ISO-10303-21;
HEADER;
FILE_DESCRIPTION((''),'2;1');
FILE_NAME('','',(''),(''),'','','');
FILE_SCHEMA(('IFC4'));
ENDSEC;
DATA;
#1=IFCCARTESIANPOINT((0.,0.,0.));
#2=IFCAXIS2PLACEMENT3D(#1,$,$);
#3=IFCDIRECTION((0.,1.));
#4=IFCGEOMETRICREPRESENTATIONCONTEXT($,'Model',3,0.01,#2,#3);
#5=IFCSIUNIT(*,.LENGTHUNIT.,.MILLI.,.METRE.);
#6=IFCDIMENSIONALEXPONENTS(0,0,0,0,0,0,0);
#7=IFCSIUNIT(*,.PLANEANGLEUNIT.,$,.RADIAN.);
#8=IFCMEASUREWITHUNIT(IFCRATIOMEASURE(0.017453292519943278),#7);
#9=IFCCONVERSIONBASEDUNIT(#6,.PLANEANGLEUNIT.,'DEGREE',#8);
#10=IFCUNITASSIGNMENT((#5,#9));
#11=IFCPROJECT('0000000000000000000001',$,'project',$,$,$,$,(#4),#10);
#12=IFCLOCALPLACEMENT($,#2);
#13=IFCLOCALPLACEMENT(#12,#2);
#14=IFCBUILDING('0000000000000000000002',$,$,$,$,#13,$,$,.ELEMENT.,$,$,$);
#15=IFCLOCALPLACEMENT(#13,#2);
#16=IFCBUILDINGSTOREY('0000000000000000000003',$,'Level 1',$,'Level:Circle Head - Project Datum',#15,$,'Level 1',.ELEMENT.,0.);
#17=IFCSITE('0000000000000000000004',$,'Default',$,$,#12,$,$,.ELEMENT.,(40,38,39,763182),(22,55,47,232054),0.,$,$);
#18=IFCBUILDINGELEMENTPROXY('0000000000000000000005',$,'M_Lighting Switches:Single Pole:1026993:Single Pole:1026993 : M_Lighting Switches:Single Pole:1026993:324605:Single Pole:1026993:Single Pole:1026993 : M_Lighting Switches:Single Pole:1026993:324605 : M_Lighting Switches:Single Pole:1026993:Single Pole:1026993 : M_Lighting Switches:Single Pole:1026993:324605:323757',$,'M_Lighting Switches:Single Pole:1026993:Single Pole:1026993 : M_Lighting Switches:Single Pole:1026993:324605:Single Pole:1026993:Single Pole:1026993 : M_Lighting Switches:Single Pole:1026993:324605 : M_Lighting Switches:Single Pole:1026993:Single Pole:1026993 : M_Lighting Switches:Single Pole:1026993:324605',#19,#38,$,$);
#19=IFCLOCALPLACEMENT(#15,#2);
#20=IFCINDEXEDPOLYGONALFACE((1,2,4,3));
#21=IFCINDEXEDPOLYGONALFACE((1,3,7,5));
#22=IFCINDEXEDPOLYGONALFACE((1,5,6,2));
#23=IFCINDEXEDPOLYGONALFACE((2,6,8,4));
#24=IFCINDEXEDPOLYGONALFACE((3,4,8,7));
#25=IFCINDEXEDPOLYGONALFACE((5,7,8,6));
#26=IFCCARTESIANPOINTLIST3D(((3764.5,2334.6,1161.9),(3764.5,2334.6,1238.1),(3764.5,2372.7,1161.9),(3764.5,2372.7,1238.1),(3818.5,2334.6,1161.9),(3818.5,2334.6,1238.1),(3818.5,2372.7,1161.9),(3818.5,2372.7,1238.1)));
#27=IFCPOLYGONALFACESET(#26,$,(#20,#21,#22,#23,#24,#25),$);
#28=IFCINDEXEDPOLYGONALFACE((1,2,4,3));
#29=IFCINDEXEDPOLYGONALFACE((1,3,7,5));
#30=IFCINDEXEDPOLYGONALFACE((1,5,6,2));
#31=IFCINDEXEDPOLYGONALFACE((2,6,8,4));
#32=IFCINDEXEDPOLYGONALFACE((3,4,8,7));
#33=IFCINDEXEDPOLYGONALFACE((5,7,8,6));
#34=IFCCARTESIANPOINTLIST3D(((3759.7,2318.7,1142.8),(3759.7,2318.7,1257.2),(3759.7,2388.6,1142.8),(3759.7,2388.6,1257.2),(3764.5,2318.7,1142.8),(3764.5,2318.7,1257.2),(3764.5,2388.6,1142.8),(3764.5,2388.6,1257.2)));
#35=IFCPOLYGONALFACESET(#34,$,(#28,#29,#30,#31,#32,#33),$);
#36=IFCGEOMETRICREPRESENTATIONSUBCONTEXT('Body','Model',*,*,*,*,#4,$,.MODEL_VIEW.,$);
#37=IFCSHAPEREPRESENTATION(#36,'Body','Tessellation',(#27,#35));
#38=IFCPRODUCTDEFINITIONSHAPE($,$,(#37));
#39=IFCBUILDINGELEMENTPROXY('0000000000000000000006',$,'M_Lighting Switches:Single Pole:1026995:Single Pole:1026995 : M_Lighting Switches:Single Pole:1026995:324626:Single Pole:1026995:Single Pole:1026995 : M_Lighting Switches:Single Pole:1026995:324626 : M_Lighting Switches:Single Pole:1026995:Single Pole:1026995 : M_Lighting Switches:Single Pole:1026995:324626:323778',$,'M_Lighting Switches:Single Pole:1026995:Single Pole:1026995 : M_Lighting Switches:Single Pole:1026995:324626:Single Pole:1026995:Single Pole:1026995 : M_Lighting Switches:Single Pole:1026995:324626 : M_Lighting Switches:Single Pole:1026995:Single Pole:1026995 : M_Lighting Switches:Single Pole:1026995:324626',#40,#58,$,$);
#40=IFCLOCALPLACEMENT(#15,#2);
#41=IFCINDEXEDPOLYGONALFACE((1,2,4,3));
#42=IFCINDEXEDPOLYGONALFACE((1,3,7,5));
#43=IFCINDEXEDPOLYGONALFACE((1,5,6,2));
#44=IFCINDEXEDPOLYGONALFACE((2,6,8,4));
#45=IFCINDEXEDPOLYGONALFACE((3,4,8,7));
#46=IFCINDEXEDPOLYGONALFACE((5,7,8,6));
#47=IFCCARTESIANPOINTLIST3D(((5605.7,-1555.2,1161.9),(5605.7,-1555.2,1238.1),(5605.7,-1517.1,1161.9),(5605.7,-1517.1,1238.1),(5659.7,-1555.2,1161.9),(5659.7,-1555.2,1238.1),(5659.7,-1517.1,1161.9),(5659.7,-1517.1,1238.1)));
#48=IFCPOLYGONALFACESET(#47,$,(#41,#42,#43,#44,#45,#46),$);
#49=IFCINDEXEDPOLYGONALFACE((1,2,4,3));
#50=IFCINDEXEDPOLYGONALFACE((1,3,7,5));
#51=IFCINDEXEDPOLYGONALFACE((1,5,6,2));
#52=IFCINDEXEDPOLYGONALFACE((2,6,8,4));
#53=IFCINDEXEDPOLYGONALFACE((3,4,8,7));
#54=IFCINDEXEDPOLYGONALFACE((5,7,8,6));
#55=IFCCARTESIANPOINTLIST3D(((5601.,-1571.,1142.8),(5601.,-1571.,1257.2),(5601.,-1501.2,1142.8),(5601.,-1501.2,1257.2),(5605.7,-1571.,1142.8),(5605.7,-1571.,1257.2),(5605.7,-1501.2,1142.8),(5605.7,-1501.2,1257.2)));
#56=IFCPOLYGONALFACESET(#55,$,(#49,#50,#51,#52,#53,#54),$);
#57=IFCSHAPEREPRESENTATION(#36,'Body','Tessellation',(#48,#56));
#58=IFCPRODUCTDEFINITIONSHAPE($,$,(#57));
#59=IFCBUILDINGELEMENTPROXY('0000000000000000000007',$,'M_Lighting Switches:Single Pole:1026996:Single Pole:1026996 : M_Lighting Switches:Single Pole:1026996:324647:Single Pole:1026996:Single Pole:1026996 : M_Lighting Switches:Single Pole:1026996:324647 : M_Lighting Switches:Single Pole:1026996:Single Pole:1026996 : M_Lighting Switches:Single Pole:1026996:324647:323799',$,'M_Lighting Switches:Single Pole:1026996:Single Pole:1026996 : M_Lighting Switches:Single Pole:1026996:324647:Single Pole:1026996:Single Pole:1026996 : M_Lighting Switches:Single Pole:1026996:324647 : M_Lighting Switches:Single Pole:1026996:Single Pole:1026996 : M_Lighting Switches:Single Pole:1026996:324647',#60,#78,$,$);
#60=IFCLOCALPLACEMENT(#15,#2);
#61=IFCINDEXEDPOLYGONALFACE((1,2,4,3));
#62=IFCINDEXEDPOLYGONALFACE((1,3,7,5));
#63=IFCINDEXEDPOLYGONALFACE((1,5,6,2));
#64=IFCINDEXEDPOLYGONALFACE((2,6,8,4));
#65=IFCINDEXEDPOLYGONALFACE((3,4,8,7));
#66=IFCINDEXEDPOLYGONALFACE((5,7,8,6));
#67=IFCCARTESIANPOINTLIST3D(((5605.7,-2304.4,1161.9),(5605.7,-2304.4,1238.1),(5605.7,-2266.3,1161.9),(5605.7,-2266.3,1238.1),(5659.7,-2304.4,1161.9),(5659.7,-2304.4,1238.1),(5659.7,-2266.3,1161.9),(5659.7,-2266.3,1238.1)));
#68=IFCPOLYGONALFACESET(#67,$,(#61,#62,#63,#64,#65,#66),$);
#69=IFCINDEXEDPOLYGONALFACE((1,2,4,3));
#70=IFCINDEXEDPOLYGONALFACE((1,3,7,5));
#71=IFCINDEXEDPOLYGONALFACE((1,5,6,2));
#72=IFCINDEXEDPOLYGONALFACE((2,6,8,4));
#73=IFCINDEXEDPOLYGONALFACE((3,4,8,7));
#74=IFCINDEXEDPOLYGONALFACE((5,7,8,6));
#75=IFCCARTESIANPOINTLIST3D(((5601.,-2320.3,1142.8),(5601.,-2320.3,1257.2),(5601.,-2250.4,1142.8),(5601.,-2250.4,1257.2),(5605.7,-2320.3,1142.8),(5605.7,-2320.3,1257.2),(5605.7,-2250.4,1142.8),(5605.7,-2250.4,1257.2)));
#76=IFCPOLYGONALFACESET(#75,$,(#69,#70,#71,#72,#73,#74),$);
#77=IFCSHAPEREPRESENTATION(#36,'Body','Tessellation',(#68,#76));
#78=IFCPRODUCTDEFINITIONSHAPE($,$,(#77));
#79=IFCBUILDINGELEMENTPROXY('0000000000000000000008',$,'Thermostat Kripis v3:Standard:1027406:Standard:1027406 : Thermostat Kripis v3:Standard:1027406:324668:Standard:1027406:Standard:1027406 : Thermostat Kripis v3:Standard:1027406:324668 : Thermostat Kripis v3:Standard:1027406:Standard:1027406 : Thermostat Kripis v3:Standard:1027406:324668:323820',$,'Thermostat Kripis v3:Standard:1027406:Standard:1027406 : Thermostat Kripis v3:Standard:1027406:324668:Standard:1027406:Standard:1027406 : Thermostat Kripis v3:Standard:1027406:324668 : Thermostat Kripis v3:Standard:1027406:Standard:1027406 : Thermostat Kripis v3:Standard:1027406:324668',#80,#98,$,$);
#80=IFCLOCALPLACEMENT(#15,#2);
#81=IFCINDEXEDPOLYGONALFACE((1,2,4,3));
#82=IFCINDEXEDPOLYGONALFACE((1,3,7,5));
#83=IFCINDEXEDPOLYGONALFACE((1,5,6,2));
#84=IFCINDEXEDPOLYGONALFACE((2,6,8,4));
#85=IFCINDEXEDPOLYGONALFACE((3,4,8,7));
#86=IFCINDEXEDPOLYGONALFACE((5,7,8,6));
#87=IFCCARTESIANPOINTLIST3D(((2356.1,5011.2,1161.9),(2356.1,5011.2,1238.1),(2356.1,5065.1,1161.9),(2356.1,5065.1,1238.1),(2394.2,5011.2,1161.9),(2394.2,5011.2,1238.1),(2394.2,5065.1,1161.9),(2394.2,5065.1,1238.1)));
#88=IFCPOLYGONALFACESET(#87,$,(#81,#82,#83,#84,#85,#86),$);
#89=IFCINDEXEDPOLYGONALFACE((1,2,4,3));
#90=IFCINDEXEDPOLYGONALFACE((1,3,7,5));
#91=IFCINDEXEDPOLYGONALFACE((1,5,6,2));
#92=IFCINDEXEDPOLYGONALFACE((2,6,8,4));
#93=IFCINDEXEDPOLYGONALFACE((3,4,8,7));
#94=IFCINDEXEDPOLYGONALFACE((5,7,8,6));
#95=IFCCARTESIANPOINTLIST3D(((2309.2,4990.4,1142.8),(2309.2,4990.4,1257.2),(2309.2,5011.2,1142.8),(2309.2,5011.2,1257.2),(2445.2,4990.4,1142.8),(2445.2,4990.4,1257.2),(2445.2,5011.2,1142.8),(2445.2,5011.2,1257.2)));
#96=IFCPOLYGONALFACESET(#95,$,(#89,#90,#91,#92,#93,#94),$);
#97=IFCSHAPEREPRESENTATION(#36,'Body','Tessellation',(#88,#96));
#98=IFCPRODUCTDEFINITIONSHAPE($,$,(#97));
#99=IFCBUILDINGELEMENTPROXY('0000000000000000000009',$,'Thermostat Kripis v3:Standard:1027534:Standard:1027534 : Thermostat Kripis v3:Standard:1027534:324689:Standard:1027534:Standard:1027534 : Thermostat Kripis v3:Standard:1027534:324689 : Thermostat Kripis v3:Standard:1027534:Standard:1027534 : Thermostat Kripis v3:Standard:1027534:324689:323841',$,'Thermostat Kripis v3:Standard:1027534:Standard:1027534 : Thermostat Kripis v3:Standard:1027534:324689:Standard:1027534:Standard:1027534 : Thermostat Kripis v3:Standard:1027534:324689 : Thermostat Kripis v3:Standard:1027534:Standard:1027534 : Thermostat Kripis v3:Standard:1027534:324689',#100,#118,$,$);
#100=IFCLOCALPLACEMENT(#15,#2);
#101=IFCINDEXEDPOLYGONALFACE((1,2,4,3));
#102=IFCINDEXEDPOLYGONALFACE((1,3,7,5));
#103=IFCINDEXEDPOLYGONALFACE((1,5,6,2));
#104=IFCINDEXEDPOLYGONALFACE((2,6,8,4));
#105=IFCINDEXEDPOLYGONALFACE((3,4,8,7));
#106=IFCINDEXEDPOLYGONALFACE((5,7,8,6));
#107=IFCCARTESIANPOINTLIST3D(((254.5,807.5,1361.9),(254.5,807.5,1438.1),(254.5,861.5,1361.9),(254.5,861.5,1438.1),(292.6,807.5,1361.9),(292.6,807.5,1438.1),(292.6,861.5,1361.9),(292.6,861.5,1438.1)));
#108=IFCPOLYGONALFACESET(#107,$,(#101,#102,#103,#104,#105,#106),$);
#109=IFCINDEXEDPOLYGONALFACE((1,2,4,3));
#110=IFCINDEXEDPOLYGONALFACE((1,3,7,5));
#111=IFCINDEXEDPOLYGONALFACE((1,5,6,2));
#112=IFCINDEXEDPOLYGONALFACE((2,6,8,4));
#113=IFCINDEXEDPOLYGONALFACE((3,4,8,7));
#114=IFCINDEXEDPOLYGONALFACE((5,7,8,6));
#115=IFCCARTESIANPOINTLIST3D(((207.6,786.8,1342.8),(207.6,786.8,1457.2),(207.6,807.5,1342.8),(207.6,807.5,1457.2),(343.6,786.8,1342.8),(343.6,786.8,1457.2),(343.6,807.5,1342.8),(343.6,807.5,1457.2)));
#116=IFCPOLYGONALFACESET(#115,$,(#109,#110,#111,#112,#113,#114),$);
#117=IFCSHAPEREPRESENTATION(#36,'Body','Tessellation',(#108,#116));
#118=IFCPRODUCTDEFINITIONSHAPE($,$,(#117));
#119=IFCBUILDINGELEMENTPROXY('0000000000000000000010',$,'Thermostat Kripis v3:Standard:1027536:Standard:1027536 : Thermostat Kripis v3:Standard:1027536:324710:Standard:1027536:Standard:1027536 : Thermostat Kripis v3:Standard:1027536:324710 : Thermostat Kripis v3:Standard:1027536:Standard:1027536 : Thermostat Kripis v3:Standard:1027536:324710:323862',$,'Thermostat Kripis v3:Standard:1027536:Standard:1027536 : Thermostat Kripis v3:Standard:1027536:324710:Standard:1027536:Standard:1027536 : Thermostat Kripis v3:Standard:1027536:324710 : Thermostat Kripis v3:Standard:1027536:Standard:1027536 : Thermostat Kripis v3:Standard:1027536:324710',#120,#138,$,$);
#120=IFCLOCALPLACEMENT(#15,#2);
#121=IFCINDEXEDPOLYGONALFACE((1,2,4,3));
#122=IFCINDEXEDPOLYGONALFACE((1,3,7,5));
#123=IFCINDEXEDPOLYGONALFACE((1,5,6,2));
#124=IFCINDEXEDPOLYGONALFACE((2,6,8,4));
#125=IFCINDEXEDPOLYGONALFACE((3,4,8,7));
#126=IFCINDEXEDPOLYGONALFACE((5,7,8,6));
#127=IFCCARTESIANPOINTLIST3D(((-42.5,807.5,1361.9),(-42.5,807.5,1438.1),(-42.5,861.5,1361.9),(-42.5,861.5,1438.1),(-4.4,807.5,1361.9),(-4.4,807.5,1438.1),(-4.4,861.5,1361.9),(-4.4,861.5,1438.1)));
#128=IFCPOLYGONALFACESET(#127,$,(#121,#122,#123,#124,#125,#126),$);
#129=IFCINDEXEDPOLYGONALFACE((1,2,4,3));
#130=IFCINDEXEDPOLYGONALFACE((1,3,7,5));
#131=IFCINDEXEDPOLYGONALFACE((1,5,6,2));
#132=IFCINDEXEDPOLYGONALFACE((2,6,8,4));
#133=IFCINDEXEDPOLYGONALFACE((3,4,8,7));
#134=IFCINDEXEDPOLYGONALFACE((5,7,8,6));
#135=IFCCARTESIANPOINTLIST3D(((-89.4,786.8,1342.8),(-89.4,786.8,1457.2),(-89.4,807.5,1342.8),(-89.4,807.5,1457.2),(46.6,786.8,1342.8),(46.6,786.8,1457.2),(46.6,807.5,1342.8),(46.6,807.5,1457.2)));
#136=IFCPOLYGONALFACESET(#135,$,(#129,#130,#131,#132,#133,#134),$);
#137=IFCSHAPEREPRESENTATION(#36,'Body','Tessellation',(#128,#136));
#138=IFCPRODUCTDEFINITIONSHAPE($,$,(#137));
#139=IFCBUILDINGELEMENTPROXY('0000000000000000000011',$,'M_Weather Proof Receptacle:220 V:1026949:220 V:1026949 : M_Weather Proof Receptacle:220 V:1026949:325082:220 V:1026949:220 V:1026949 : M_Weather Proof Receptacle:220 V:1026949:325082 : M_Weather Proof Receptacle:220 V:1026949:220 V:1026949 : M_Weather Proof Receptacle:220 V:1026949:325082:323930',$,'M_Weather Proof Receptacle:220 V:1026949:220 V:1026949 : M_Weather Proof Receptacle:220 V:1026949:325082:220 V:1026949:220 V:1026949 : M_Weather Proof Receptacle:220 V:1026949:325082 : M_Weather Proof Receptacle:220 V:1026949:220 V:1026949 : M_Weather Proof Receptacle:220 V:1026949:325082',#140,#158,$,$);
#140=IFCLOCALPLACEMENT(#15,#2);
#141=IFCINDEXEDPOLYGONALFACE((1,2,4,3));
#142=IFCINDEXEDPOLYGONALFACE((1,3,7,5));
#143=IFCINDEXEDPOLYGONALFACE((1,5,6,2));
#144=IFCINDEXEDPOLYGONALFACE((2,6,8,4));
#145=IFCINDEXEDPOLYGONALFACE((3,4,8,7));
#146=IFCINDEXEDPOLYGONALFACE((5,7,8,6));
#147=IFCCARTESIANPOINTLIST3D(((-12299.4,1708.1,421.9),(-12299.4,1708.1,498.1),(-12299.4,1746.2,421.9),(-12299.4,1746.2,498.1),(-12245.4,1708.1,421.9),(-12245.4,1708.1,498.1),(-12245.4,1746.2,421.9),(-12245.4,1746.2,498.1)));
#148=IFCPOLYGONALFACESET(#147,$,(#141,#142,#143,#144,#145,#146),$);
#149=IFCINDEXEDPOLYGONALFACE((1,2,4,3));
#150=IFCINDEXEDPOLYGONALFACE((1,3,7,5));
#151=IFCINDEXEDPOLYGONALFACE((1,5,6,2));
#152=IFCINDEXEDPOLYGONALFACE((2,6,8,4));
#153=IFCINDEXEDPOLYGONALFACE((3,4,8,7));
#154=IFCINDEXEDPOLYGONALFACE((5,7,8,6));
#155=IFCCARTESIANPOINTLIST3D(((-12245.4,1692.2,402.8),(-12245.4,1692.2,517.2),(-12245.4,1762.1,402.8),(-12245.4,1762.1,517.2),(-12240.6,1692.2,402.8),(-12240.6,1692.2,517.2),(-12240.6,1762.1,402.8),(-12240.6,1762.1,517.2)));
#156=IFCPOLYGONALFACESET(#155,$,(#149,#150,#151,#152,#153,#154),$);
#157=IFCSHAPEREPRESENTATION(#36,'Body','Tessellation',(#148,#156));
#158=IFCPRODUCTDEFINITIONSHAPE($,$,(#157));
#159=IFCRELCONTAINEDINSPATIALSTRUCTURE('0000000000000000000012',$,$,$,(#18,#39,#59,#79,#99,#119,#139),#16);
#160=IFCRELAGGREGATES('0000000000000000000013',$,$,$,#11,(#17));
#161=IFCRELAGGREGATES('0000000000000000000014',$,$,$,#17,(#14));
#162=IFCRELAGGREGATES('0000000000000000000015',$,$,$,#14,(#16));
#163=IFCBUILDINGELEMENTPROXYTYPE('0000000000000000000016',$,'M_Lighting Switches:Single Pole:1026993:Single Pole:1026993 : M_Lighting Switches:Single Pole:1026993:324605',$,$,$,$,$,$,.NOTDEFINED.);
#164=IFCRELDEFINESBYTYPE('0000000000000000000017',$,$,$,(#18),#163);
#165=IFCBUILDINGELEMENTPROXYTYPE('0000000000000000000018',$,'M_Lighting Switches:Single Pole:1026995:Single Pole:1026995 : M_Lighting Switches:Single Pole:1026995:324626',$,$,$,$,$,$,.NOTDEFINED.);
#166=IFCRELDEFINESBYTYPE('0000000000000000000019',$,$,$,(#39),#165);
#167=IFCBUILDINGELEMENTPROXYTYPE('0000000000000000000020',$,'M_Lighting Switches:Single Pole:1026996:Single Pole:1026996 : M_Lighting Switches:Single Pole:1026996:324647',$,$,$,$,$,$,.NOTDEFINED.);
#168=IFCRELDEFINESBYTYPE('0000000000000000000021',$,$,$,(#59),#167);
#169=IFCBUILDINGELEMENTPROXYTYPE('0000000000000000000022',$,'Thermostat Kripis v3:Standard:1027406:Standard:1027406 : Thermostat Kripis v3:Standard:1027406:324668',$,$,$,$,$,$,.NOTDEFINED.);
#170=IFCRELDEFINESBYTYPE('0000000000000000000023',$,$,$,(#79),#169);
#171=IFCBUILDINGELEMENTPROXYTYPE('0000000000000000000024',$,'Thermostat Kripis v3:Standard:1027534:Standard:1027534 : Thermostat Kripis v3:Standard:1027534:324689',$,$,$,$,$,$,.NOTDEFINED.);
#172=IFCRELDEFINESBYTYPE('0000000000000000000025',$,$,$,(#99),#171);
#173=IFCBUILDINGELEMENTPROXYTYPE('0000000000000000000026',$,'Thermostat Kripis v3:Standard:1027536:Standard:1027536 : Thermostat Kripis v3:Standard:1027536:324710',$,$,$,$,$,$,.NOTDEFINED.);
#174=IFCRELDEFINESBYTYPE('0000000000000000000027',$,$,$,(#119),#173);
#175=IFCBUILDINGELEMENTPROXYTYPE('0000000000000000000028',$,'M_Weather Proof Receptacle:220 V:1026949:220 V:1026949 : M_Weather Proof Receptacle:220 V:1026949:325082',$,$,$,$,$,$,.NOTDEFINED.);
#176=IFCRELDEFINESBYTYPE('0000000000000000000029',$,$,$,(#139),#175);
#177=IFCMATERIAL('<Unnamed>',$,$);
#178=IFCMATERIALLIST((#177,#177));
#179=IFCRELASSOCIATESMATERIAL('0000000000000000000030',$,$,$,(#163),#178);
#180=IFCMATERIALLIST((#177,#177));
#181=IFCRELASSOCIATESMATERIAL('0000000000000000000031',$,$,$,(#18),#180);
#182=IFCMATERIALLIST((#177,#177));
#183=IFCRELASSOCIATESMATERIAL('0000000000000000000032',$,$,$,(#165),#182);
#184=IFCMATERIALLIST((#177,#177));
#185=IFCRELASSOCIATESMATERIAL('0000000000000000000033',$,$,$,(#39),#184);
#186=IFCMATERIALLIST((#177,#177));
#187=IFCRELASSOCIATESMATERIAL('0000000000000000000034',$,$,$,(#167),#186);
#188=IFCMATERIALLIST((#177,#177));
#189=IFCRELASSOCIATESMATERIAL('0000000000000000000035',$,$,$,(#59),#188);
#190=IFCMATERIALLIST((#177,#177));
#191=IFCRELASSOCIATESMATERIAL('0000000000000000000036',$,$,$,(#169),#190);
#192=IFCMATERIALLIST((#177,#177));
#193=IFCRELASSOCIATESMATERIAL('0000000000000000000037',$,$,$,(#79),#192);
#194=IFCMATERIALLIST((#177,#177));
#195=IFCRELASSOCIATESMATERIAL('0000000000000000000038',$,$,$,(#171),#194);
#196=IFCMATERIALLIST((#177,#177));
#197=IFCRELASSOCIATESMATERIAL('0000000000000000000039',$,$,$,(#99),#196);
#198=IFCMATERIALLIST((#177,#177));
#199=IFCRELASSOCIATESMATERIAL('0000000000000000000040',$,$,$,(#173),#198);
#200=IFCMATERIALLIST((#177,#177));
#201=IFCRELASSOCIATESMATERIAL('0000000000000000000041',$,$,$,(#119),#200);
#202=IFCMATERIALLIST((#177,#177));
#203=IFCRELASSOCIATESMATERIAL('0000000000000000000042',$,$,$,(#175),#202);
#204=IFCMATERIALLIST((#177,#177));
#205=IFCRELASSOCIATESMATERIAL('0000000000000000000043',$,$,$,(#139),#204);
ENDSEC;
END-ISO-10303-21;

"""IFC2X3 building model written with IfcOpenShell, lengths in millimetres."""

from ifc_helpers import new_model, entity, si_unit, converted_unit, direction, frame, frame_2d, origin, origin_2d_with_axis, place, context, subcontext, project, spatial, rectangle, extrude, source, transform, mapped, material, material_list, type_object, type_shapes, element, save


model = new_model("IFC2X3")

# Units and contexts
model_context = context("Model", 3, precision=0.01, world=origin(), true_north=direction((0.0, 1.0)))
body_context = subcontext(model_context, "Body", "Model", "MODEL_VIEW")
ifc_project = project(units=[si_unit("LENGTHUNIT", "METRE", prefix="MILLI"), converted_unit("PLANEANGLEUNIT", "DEGREE", entity("IfcRatioMeasure", 0.017453292519943278), si_unit("PLANEANGLEUNIT", "RADIAN"), dimensions=[0, 0, 0, 0, 0, 0, 0])], contexts=[model_context])

# Site, building, storey
site_placement = place(None, origin())
site = spatial("IfcSite", under=ifc_project, at=site_placement, Name="Default", CompositionType="ELEMENT", RefLatitude=(40, 38, 39, 763182), RefLongitude=(22, 55, 47, 232054), RefElevation=0.0)
building_placement = place(site_placement, origin())
building = spatial("IfcBuilding", under=site, at=building_placement, CompositionType="ELEMENT")
storey_placement = place(building_placement, origin())
storey = spatial("IfcBuildingStorey", under=building, at=storey_placement, Name="Level 1", ObjectType="Level:Circle Head - Project Datum", LongName="Level 1", CompositionType="ELEMENT", Elevation=0.0)

# Shared definitions
ifc_material = material(Name="<Unnamed>")

# Building element proxies
ifc_material_list_1 = material_list([ifc_material, ifc_material])
ifc_material_list_2 = material_list([ifc_material, ifc_material])
building_element_proxy_type_1 = type_object("IfcBuildingElementProxyType", Name="M_Lighting Switches:Single Pole:1026993:Single Pole:1026993 : M_Lighting Switches:Single Pole:1026993:324605", PredefinedType="NOTDEFINED", material=ifc_material_list_2)
shared_shape_1 = source(origin(), body_context, "Body", "SweptSolid", [
    extrude(rectangle(XDim=38.1, YDim=54.0, at=origin_2d_with_axis()), frame((3791.5, 2353.7, 1161.9), z_axis=(0.0, 0.0, 1.0), x_axis=(0.0, 1.0, 0.0)), (0.0, 0.0, 1.0), 76.2),
    extrude(rectangle(XDim=69.8, YDim=4.8, at=origin_2d_with_axis()), frame((3762.1, 2353.7, 1142.8), z_axis=(0.0, 0.0, 1.0), x_axis=(0.0, 1.0, 0.0)), (0.0, 0.0, 1.0), 114.3),
])
type_shapes(building_element_proxy_type_1, [shared_shape_1])
proxy_1_placement = place(storey_placement, origin())
element("IfcBuildingElementProxy", 1, at=proxy_1_placement, inside=storey, type_object=building_element_proxy_type_1, material=ifc_material_list_1, Name="M_Lighting Switches:Single Pole:1026993:Single Pole:1026993 : M_Lighting Switches:Single Pole:1026993:324605:Single Pole:1026993:Single Pole:1026993 : M_Lighting Switches:Single Pole:1026993:324605 : M_Lighting Switches:Single Pole:1026993:Single Pole:1026993 : M_Lighting Switches:Single Pole:1026993:324605:323757", ObjectType="M_Lighting Switches:Single Pole:1026993:Single Pole:1026993 : M_Lighting Switches:Single Pole:1026993:324605:Single Pole:1026993:Single Pole:1026993 : M_Lighting Switches:Single Pole:1026993:324605 : M_Lighting Switches:Single Pole:1026993:Single Pole:1026993 : M_Lighting Switches:Single Pole:1026993:324605", context=body_context, shape_type="MappedRepresentation", body=[
    mapped(shared_shape_1, transform((0.0, 0.0, 0.0), scale=1.0)),
])
ifc_material_list_3 = material_list([ifc_material, ifc_material])
ifc_material_list_4 = material_list([ifc_material, ifc_material])
building_element_proxy_type_2 = type_object("IfcBuildingElementProxyType", Name="M_Lighting Switches:Single Pole:1026995:Single Pole:1026995 : M_Lighting Switches:Single Pole:1026995:324626", PredefinedType="NOTDEFINED", material=ifc_material_list_4)
shared_shape_2 = source(origin(), body_context, "Body", "SweptSolid", [
    extrude(rectangle(XDim=38.1, YDim=54.0, at=origin_2d_with_axis()), frame((5632.7, -1536.1, 1161.9), z_axis=(0.0, 0.0, 1.0), x_axis=(0.0, 1.0, 0.0)), (0.0, 0.0, 1.0), 76.2),
    extrude(rectangle(XDim=69.8, YDim=4.8, at=frame_2d((0.0, 0.0), x_axis=(1.0, 0.0))), frame((5603.3, -1536.1, 1142.8), z_axis=(0.0, 0.0, 1.0), x_axis=(0.0, 1.0, 0.0)), (0.0, 0.0, 1.0), 114.3),
])
type_shapes(building_element_proxy_type_2, [shared_shape_2])
proxy_2_placement = place(storey_placement, origin())
element("IfcBuildingElementProxy", 2, at=proxy_2_placement, inside=storey, type_object=building_element_proxy_type_2, material=ifc_material_list_3, Name="M_Lighting Switches:Single Pole:1026995:Single Pole:1026995 : M_Lighting Switches:Single Pole:1026995:324626:Single Pole:1026995:Single Pole:1026995 : M_Lighting Switches:Single Pole:1026995:324626 : M_Lighting Switches:Single Pole:1026995:Single Pole:1026995 : M_Lighting Switches:Single Pole:1026995:324626:323778", ObjectType="M_Lighting Switches:Single Pole:1026995:Single Pole:1026995 : M_Lighting Switches:Single Pole:1026995:324626:Single Pole:1026995:Single Pole:1026995 : M_Lighting Switches:Single Pole:1026995:324626 : M_Lighting Switches:Single Pole:1026995:Single Pole:1026995 : M_Lighting Switches:Single Pole:1026995:324626", context=body_context, shape_type="MappedRepresentation", body=[
    mapped(shared_shape_2, transform((0.0, 0.0, 0.0), scale=1.0)),
])
ifc_material_list_5 = material_list([ifc_material, ifc_material])
ifc_material_list_6 = material_list([ifc_material, ifc_material])
building_element_proxy_type_3 = type_object("IfcBuildingElementProxyType", Name="M_Lighting Switches:Single Pole:1026996:Single Pole:1026996 : M_Lighting Switches:Single Pole:1026996:324647", PredefinedType="NOTDEFINED", material=ifc_material_list_6)
shared_shape_3 = source(origin(), body_context, "Body", "SweptSolid", [
    extrude(rectangle(XDim=38.1, YDim=54.0, at=origin_2d_with_axis()), frame((5632.7, -2285.3, 1161.9), z_axis=(0.0, 0.0, 1.0), x_axis=(0.0, 1.0, 0.0)), (0.0, 0.0, 1.0), 76.2),
    extrude(rectangle(XDim=69.8, YDim=4.8, at=frame_2d((0.0, 0.0), x_axis=(1.0, 0.0))), frame((5603.3, -2285.3, 1142.8), z_axis=(0.0, 0.0, 1.0), x_axis=(0.0, 1.0, 0.0)), (0.0, 0.0, 1.0), 114.3),
])
type_shapes(building_element_proxy_type_3, [shared_shape_3])
proxy_3_placement = place(storey_placement, origin())
element("IfcBuildingElementProxy", 3, at=proxy_3_placement, inside=storey, type_object=building_element_proxy_type_3, material=ifc_material_list_5, Name="M_Lighting Switches:Single Pole:1026996:Single Pole:1026996 : M_Lighting Switches:Single Pole:1026996:324647:Single Pole:1026996:Single Pole:1026996 : M_Lighting Switches:Single Pole:1026996:324647 : M_Lighting Switches:Single Pole:1026996:Single Pole:1026996 : M_Lighting Switches:Single Pole:1026996:324647:323799", ObjectType="M_Lighting Switches:Single Pole:1026996:Single Pole:1026996 : M_Lighting Switches:Single Pole:1026996:324647:Single Pole:1026996:Single Pole:1026996 : M_Lighting Switches:Single Pole:1026996:324647 : M_Lighting Switches:Single Pole:1026996:Single Pole:1026996 : M_Lighting Switches:Single Pole:1026996:324647", context=body_context, shape_type="MappedRepresentation", body=[
    mapped(shared_shape_3, transform((0.0, 0.0, 0.0), scale=1.0)),
])
ifc_material_list_7 = material_list([ifc_material, ifc_material])
ifc_material_list_8 = material_list([ifc_material, ifc_material])
building_element_proxy_type_4 = type_object("IfcBuildingElementProxyType", Name="Thermostat Kripis v3:Standard:1027406:Standard:1027406 : Thermostat Kripis v3:Standard:1027406:324668", PredefinedType="NOTDEFINED", material=ifc_material_list_8)
shared_shape_4 = source(origin(), body_context, "Body", "SweptSolid", [
    extrude(rectangle(XDim=38.1, YDim=54.0, at=origin_2d_with_axis()), frame((2375.1, 5038.1, 1161.9), z_axis=(0.0, 0.0, 1.0), x_axis=(-1.0, 0.0, 0.0)), (0.0, 0.0, 1.0), 76.2),
    extrude(rectangle(XDim=136.0, YDim=20.7, at=frame_2d((0.0, 0.0), x_axis=(1.0, 0.0))), frame((2377.2, 5000.8, 1142.8), z_axis=(0.0, 0.0, 1.0), x_axis=(-1.0, 0.0, 0.0)), (0.0, 0.0, 1.0), 114.3),
])
type_shapes(building_element_proxy_type_4, [shared_shape_4])
proxy_4_placement = place(storey_placement, origin())
element("IfcBuildingElementProxy", 4, at=proxy_4_placement, inside=storey, type_object=building_element_proxy_type_4, material=ifc_material_list_7, Name="Thermostat Kripis v3:Standard:1027406:Standard:1027406 : Thermostat Kripis v3:Standard:1027406:324668:Standard:1027406:Standard:1027406 : Thermostat Kripis v3:Standard:1027406:324668 : Thermostat Kripis v3:Standard:1027406:Standard:1027406 : Thermostat Kripis v3:Standard:1027406:324668:323820", ObjectType="Thermostat Kripis v3:Standard:1027406:Standard:1027406 : Thermostat Kripis v3:Standard:1027406:324668:Standard:1027406:Standard:1027406 : Thermostat Kripis v3:Standard:1027406:324668 : Thermostat Kripis v3:Standard:1027406:Standard:1027406 : Thermostat Kripis v3:Standard:1027406:324668", context=body_context, shape_type="MappedRepresentation", body=[
    mapped(shared_shape_4, transform((0.0, 0.0, 0.0), scale=1.0)),
])
ifc_material_list_9 = material_list([ifc_material, ifc_material])
ifc_material_list_10 = material_list([ifc_material, ifc_material])
building_element_proxy_type_5 = type_object("IfcBuildingElementProxyType", Name="Thermostat Kripis v3:Standard:1027534:Standard:1027534 : Thermostat Kripis v3:Standard:1027534:324689", PredefinedType="NOTDEFINED", material=ifc_material_list_10)
shared_shape_5 = source(origin(), body_context, "Body", "SweptSolid", [
    extrude(rectangle(XDim=38.1, YDim=54.0, at=frame_2d((0.0, 0.0), x_axis=(1.0, 0.0))), frame((273.5, 834.5, 1361.9), z_axis=(0.0, 0.0, 1.0), x_axis=(-1.0, 0.0, 0.0)), (0.0, 0.0, 1.0), 76.2),
    extrude(rectangle(XDim=136.0, YDim=20.7, at=origin_2d_with_axis()), frame((275.6, 797.2, 1342.8), z_axis=(0.0, 0.0, 1.0), x_axis=(-1.0, 0.0, 0.0)), (0.0, 0.0, 1.0), 114.3),
])
type_shapes(building_element_proxy_type_5, [shared_shape_5])
proxy_5_placement = place(storey_placement, origin())
element("IfcBuildingElementProxy", 5, at=proxy_5_placement, inside=storey, type_object=building_element_proxy_type_5, material=ifc_material_list_9, Name="Thermostat Kripis v3:Standard:1027534:Standard:1027534 : Thermostat Kripis v3:Standard:1027534:324689:Standard:1027534:Standard:1027534 : Thermostat Kripis v3:Standard:1027534:324689 : Thermostat Kripis v3:Standard:1027534:Standard:1027534 : Thermostat Kripis v3:Standard:1027534:324689:323841", ObjectType="Thermostat Kripis v3:Standard:1027534:Standard:1027534 : Thermostat Kripis v3:Standard:1027534:324689:Standard:1027534:Standard:1027534 : Thermostat Kripis v3:Standard:1027534:324689 : Thermostat Kripis v3:Standard:1027534:Standard:1027534 : Thermostat Kripis v3:Standard:1027534:324689", context=body_context, shape_type="MappedRepresentation", body=[
    mapped(shared_shape_5, transform((0.0, 0.0, 0.0), scale=1.0)),
])
ifc_material_list_11 = material_list([ifc_material, ifc_material])
ifc_material_list_12 = material_list([ifc_material, ifc_material])
building_element_proxy_type_6 = type_object("IfcBuildingElementProxyType", Name="Thermostat Kripis v3:Standard:1027536:Standard:1027536 : Thermostat Kripis v3:Standard:1027536:324710", PredefinedType="NOTDEFINED", material=ifc_material_list_12)
shared_shape_6 = source(origin(), body_context, "Body", "SweptSolid", [
    extrude(rectangle(XDim=38.1, YDim=54.0, at=frame_2d((0.0, 0.0), x_axis=(1.0, 0.0))), frame((-23.5, 834.5, 1361.9), z_axis=(0.0, 0.0, 1.0), x_axis=(-1.0, 0.0, 0.0)), (0.0, 0.0, 1.0), 76.2),
    extrude(rectangle(XDim=136.0, YDim=20.7, at=frame_2d((0.0, 0.0), x_axis=(1.0, 0.0))), frame((-21.4, 797.2, 1342.8), z_axis=(0.0, 0.0, 1.0), x_axis=(-1.0, 0.0, 0.0)), (0.0, 0.0, 1.0), 114.3),
])
type_shapes(building_element_proxy_type_6, [shared_shape_6])
proxy_6_placement = place(storey_placement, origin())
element("IfcBuildingElementProxy", 6, at=proxy_6_placement, inside=storey, type_object=building_element_proxy_type_6, material=ifc_material_list_11, Name="Thermostat Kripis v3:Standard:1027536:Standard:1027536 : Thermostat Kripis v3:Standard:1027536:324710:Standard:1027536:Standard:1027536 : Thermostat Kripis v3:Standard:1027536:324710 : Thermostat Kripis v3:Standard:1027536:Standard:1027536 : Thermostat Kripis v3:Standard:1027536:324710:323862", ObjectType="Thermostat Kripis v3:Standard:1027536:Standard:1027536 : Thermostat Kripis v3:Standard:1027536:324710:Standard:1027536:Standard:1027536 : Thermostat Kripis v3:Standard:1027536:324710 : Thermostat Kripis v3:Standard:1027536:Standard:1027536 : Thermostat Kripis v3:Standard:1027536:324710", context=body_context, shape_type="MappedRepresentation", body=[
    mapped(shared_shape_6, transform((0.0, 0.0, 0.0), scale=1.0)),
])
ifc_material_list_13 = material_list([ifc_material, ifc_material])
ifc_material_list_14 = material_list([ifc_material, ifc_material])
building_element_proxy_type_7 = type_object("IfcBuildingElementProxyType", Name="M_Weather Proof Receptacle:220 V:1026949:220 V:1026949 : M_Weather Proof Receptacle:220 V:1026949:325082", PredefinedType="NOTDEFINED", material=ifc_material_list_14)
shared_shape_7 = source(origin(), body_context, "Body", "SweptSolid", [
    extrude(rectangle(XDim=38.1, YDim=54.0, at=frame_2d((0.0, 0.0), x_axis=(1.0, 0.0))), frame((-12272.4, 1727.2, 421.9), z_axis=(0.0, 0.0, 1.0), x_axis=(0.0, -1.0, 0.0)), (0.0, 0.0, 1.0), 76.2),
    extrude(rectangle(XDim=69.8, YDim=4.8, at=origin_2d_with_axis()), frame((-12243.0, 1727.2, 402.8), z_axis=(0.0, 0.0, 1.0), x_axis=(0.0, -1.0, 0.0)), (0.0, 0.0, 1.0), 114.3),
])
type_shapes(building_element_proxy_type_7, [shared_shape_7])
proxy_7_placement = place(storey_placement, origin())
element("IfcBuildingElementProxy", 7, at=proxy_7_placement, inside=storey, type_object=building_element_proxy_type_7, material=ifc_material_list_13, Name="M_Weather Proof Receptacle:220 V:1026949:220 V:1026949 : M_Weather Proof Receptacle:220 V:1026949:325082:220 V:1026949:220 V:1026949 : M_Weather Proof Receptacle:220 V:1026949:325082 : M_Weather Proof Receptacle:220 V:1026949:220 V:1026949 : M_Weather Proof Receptacle:220 V:1026949:325082:323930", ObjectType="M_Weather Proof Receptacle:220 V:1026949:220 V:1026949 : M_Weather Proof Receptacle:220 V:1026949:325082:220 V:1026949:220 V:1026949 : M_Weather Proof Receptacle:220 V:1026949:325082 : M_Weather Proof Receptacle:220 V:1026949:220 V:1026949 : M_Weather Proof Receptacle:220 V:1026949:325082", context=body_context, shape_type="MappedRepresentation", body=[
    mapped(shared_shape_7, transform((0.0, 0.0, 0.0), scale=1.0)),
])

save(model, "model.ifc")
